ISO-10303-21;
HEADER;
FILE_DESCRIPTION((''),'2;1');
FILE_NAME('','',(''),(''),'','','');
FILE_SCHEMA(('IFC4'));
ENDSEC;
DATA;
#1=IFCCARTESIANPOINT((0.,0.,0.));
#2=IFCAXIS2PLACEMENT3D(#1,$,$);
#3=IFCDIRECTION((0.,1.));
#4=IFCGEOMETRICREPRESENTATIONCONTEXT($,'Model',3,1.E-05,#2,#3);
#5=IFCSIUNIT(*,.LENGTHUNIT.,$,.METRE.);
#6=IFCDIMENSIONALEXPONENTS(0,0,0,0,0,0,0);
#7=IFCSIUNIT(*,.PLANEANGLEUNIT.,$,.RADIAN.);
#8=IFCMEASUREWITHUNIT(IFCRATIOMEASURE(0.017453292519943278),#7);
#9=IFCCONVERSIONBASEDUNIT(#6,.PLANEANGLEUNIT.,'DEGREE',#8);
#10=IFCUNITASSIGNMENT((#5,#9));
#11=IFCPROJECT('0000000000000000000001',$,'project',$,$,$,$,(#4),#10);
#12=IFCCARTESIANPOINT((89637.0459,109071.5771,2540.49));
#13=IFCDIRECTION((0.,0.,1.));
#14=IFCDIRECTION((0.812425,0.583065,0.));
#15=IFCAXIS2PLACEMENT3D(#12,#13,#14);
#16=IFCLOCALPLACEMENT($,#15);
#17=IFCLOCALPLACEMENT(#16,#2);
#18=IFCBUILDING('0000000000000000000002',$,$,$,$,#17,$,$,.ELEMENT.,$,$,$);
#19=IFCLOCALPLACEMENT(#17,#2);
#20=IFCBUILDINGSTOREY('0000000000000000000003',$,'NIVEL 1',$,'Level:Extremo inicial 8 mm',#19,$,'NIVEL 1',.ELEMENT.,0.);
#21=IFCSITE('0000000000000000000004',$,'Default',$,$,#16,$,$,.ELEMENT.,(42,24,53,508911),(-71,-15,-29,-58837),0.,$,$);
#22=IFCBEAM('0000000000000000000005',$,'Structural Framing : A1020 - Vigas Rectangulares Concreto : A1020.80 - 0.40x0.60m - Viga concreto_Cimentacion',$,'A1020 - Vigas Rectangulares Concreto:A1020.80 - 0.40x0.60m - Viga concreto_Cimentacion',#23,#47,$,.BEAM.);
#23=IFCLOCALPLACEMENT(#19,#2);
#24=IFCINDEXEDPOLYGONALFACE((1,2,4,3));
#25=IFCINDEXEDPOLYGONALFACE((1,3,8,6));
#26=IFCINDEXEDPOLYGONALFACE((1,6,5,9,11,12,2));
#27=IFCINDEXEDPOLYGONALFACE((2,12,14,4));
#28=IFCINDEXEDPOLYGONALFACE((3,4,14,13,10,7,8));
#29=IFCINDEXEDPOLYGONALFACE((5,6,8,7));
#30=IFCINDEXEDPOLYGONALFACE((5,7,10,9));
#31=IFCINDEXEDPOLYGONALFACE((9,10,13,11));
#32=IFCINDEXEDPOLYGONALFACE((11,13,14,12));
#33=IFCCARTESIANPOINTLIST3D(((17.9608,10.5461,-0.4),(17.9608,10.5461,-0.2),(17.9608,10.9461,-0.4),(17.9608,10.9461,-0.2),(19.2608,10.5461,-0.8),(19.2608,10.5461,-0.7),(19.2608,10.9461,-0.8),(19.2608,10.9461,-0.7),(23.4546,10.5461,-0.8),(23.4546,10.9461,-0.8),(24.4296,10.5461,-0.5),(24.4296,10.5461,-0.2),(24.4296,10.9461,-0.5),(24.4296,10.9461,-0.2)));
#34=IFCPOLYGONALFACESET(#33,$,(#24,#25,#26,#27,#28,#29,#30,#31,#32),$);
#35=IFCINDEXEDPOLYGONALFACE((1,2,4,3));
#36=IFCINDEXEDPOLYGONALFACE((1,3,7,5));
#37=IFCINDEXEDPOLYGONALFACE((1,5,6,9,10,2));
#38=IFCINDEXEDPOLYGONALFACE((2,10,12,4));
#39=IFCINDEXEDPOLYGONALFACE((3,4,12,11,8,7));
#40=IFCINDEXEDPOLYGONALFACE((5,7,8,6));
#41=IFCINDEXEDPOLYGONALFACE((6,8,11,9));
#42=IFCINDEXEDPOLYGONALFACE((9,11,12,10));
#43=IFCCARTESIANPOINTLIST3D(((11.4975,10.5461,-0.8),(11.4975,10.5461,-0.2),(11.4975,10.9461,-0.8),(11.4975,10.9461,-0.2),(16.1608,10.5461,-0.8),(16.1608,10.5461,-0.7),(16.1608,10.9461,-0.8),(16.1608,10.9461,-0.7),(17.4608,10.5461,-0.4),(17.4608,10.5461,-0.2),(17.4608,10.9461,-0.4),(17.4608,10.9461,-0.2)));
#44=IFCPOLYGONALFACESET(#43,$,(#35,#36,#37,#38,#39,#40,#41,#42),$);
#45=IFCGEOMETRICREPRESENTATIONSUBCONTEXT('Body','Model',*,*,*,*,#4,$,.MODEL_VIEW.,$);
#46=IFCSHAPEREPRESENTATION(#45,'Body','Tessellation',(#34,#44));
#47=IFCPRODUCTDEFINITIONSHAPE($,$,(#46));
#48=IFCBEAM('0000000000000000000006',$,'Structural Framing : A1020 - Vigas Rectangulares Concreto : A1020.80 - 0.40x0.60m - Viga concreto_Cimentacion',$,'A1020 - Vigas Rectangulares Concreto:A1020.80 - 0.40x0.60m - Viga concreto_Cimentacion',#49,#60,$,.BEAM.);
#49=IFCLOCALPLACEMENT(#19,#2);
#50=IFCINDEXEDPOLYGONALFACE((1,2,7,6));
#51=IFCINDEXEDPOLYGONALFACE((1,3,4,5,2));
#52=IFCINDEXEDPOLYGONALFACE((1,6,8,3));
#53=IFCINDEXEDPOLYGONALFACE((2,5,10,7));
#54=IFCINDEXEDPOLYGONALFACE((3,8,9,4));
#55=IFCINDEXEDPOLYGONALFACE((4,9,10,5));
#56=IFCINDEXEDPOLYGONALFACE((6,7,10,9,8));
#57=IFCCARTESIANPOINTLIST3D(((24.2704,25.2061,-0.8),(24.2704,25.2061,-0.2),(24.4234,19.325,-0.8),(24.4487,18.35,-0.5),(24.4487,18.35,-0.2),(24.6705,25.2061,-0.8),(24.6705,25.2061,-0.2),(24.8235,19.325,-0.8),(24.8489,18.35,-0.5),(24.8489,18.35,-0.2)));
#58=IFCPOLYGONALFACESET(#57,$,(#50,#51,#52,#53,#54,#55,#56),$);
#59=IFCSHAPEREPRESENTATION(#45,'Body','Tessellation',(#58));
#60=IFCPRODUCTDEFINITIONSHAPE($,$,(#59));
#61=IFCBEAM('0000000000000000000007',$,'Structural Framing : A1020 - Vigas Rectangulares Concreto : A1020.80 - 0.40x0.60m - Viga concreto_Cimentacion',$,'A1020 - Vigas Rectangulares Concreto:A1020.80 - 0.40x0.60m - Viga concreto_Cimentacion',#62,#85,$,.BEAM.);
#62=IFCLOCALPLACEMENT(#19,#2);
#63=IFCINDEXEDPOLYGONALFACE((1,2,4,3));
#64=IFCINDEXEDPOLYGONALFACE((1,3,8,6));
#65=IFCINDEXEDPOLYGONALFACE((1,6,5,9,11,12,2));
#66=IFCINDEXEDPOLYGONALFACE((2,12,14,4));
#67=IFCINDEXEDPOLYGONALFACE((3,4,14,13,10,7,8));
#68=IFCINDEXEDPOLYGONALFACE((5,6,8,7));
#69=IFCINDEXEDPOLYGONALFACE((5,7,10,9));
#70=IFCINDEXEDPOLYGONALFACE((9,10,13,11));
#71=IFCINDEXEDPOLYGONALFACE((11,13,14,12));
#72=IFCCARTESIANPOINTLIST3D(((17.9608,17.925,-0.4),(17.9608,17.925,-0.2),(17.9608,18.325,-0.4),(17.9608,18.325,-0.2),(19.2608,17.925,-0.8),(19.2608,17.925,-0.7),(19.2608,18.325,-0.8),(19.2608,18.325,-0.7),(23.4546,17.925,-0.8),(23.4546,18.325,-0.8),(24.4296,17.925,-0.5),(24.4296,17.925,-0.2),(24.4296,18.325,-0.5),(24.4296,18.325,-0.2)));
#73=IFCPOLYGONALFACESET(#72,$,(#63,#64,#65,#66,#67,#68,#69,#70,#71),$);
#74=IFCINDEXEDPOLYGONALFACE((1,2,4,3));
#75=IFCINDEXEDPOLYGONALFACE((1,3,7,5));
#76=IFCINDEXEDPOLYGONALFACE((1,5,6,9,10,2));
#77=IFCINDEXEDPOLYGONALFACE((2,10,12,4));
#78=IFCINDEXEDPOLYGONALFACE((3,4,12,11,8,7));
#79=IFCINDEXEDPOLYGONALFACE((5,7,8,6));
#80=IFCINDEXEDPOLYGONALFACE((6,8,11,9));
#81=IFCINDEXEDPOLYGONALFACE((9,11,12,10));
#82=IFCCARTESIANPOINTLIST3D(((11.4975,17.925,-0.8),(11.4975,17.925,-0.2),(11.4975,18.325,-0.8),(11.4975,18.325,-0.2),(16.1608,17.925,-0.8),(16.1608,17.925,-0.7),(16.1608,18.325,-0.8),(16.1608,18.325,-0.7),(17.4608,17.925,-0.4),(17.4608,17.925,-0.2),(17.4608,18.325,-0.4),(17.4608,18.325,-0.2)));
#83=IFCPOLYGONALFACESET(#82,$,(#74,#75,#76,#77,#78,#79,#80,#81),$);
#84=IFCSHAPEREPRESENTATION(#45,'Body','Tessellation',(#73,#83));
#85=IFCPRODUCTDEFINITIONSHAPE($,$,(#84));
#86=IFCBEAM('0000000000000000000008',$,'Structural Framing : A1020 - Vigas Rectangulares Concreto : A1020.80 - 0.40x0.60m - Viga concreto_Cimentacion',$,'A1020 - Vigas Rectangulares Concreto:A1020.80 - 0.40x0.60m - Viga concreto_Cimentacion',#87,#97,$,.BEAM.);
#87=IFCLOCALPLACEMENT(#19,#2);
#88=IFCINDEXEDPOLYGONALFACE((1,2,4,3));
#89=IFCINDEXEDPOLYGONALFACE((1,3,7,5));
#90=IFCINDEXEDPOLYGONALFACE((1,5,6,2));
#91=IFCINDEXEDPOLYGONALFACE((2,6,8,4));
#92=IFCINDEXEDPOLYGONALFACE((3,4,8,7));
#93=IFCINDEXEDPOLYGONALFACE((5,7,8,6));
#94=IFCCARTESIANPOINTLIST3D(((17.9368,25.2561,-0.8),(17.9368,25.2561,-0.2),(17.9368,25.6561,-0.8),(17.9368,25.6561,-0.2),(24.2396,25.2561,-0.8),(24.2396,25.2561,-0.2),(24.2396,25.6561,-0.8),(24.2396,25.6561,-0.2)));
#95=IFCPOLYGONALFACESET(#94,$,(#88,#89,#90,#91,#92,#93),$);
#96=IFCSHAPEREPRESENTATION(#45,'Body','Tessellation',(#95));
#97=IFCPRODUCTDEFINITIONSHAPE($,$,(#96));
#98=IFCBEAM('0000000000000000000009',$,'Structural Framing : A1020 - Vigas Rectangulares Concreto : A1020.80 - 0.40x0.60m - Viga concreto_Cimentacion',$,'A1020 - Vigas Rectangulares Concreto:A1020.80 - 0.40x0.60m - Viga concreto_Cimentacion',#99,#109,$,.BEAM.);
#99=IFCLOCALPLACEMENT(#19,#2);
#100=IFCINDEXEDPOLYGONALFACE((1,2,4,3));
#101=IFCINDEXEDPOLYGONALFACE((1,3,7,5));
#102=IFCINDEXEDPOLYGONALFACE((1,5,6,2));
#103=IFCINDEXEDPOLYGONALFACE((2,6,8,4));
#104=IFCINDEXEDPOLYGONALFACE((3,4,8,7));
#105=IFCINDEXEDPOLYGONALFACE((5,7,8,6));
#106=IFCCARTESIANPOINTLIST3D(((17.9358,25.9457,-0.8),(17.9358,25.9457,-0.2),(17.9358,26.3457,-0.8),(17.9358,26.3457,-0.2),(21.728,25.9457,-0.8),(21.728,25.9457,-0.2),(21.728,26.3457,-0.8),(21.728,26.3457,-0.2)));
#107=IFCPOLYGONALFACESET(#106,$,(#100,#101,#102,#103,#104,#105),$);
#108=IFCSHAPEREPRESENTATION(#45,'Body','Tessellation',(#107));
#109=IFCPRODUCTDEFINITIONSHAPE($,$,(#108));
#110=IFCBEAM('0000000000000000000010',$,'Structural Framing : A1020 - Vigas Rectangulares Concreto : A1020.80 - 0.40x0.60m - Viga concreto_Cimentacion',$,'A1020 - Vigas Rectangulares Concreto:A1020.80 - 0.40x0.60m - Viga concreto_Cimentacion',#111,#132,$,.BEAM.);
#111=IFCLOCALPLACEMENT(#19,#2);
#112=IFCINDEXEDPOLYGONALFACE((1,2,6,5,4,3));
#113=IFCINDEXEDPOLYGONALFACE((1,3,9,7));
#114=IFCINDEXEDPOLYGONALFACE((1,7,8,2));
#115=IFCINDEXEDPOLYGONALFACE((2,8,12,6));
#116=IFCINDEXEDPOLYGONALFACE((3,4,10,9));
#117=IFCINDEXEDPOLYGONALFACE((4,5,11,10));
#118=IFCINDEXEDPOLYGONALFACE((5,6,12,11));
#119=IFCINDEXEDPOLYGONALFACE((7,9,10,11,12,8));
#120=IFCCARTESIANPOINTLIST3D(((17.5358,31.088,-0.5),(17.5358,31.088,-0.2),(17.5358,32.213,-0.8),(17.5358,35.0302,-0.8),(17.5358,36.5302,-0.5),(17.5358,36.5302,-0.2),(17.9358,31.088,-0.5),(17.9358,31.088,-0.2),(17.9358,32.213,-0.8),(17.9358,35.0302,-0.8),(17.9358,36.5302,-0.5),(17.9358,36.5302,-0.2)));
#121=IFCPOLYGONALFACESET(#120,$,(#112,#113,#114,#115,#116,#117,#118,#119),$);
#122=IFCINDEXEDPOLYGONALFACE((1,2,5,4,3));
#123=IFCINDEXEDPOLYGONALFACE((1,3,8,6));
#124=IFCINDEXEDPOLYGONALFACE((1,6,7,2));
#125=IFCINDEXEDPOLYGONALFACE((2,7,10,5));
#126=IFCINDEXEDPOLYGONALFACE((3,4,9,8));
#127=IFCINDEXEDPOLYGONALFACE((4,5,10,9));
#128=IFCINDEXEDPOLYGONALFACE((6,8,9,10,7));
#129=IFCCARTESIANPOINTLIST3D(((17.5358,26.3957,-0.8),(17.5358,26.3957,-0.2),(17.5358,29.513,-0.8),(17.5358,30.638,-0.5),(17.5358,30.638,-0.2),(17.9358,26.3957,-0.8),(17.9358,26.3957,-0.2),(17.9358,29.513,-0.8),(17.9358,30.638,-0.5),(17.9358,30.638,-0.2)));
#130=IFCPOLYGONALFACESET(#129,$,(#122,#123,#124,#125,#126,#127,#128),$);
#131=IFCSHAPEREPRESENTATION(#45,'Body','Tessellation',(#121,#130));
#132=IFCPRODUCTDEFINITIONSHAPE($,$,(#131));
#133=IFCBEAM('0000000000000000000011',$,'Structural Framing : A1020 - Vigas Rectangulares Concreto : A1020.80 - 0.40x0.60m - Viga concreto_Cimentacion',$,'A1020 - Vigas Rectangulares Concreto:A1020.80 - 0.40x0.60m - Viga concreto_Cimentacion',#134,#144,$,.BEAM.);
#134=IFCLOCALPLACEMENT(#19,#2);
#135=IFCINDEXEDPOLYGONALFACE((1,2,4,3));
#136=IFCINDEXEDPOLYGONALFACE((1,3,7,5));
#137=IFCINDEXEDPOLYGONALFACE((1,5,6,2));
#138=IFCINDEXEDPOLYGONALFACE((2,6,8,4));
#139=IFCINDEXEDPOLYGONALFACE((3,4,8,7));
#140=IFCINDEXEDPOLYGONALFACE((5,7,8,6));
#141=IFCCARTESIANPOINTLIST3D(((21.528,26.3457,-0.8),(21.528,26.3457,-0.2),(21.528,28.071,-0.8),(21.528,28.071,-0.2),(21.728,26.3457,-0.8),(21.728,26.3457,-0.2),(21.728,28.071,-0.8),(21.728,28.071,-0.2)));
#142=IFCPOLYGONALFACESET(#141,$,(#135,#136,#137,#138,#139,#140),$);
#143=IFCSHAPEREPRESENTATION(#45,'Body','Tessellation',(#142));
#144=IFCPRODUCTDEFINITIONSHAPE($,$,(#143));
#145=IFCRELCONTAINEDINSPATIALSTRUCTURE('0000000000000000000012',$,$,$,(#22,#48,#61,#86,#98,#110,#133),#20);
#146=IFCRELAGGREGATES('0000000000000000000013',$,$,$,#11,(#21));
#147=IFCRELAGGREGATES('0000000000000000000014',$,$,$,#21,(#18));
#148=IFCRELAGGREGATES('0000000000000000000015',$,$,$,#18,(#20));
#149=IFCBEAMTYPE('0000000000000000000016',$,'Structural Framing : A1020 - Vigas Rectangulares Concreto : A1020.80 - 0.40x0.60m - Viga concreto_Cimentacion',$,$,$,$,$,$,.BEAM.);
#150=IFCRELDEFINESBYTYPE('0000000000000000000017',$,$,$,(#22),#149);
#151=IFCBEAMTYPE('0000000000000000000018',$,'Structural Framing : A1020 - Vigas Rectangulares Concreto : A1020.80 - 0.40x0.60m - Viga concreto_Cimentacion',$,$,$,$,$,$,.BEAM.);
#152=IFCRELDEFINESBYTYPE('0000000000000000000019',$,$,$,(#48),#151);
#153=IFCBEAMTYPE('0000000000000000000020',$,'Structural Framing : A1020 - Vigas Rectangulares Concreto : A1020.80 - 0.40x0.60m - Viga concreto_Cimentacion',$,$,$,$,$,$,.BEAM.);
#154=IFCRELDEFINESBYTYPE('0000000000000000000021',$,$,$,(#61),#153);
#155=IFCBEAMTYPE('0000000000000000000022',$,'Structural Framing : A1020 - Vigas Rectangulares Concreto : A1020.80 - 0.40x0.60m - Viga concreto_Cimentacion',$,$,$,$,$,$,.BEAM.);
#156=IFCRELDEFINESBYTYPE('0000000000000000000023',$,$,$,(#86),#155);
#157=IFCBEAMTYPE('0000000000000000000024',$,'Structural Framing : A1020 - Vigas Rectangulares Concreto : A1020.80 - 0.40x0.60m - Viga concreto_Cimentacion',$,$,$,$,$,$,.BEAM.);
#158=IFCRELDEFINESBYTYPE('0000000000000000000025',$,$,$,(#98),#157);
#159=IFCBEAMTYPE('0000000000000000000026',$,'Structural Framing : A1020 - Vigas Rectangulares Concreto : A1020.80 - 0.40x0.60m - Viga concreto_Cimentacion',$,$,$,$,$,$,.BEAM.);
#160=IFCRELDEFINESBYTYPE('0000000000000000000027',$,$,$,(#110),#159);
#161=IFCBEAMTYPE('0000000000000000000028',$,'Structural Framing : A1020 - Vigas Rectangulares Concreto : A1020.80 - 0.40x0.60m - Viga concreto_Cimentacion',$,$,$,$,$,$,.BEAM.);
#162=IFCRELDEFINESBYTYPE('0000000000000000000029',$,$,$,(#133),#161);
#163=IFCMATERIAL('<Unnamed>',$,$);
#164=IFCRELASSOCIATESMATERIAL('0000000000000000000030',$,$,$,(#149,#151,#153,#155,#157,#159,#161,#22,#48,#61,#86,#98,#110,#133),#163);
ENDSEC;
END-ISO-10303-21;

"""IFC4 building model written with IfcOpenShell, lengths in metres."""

from ifc_helpers import new_model, entity, si_unit, converted_unit, direction, frame, frame_2d, origin, place, context, subcontext, project, spatial, polyline, segment, composite_curve, rectangle, outline, extrude, clip, halfspace, bounded_halfspace, source, transform, mapped, material, material_profile, profile_set, profile_usage, type_object, type_shapes, element, save


model = new_model("IFC4")

# Units and contexts
model_context = context("Model", 3, precision=1e-05, world=origin(), true_north=direction((0.0, 1.0)))
body_context = subcontext(model_context, "Body", "Model", "MODEL_VIEW")
ifc_project = project(units=[si_unit("LENGTHUNIT", "METRE"), converted_unit("PLANEANGLEUNIT", "DEGREE", entity("IfcRatioMeasure", 0.017453292519943278), si_unit("PLANEANGLEUNIT", "RADIAN"), dimensions=[0, 0, 0, 0, 0, 0, 0])], contexts=[model_context])

# Site, building, storey
site_placement = place(None, frame((89637.0459, 109071.5771, 2540.49), z_axis=(0.0, 0.0, 1.0), x_axis=(0.812425, 0.583065, 0.0)))
site = spatial("IfcSite", under=ifc_project, at=site_placement, Name="Default", CompositionType="ELEMENT", RefLatitude=(42, 24, 53, 508911), RefLongitude=(-71, -15, -29, -58837), RefElevation=0.0)
building_placement = place(site_placement, origin())
building = spatial("IfcBuilding", under=site, at=building_placement, CompositionType="ELEMENT")
storey_placement = place(building_placement, origin())
storey = spatial("IfcBuildingStorey", under=building, at=storey_placement, Name="NIVEL 1", ObjectType="Level:Extremo inicial 8 mm", LongName="NIVEL 1", CompositionType="ELEMENT", Elevation=0.0)

# Shared definitions
ifc_material_1 = material(Name="<Unnamed>")

# Beams
ifc_material_profile_1 = material_profile(ifc_material_1, outline(composite_curve([segment(polyline([(-0.2, 0.3, 0.0), (0.2, 0.3, 0.0)]), True, "CONTINUOUS"), segment(polyline([(0.2, 0.3, 0.0), (0.2, -0.3, 0.0)]), True, "CONTINUOUS"), segment(polyline([(0.2, -0.3, 0.0), (-0.2, -0.3, 0.0)]), True, "CONTINUOUS"), segment(polyline([(-0.2, -0.3, 0.0), (-0.2, 0.3, 0.0)]), True, "CONTINUOUS")], self_intersect=False), kind="CURVE"), Name="A1020.80 - 0.40x0.60m - Viga concreto_Cimentacion")
ifc_material_profile_2 = material_profile(ifc_material_1, outline(composite_curve([segment(polyline([(6.4409, -0.2, 0.3), (6.4409, -0.2, -0.3)]), True, "CONTINUOUS"), segment(polyline([(6.4409, -0.2, -0.3), (6.4409, 0.2, -0.3)]), True, "CONTINUOUS"), segment(polyline([(6.4409, 0.2, -0.3), (6.4409, 0.2, 0.3)]), True, "CONTINUOUS"), segment(polyline([(6.4409, 0.2, 0.3), (6.4409, -0.2, 0.3)]), True, "CONTINUOUS")], self_intersect=False), kind="CURVE"), Name="A1020.80 - 0.40x0.60m - Viga concreto_Cimentacion")
ifc_profile_set_1 = profile_set([ifc_material_profile_1, ifc_material_profile_2], Name="A1020.80 - 0.40x0.60m - Viga concreto_Cimentacion")
ifc_profile_usage_1 = profile_usage(ifc_profile_set_1, cardinal=8)
beam_type_1 = type_object("IfcBeamType", Name="Structural Framing : A1020 - Vigas Rectangulares Concreto : A1020.80 - 0.40x0.60m - Viga concreto_Cimentacion", PredefinedType="BEAM", material=ifc_profile_set_1)
shared_shape_1 = source(origin(), body_context, "Body", "SweptSolid", [
    clip(clip(clip(extrude(rectangle(XDim=0.6, YDim=0.4, at=frame_2d((0.0, 0.0), x_axis=(0.0, 1.0))), frame((17.9608, 10.7461, -0.5), z_axis=(1.0, 0.0, 0.0), x_axis=(0.0, 1.0, 0.0)), (0.0, 0.0, 1.0), 6.4688), halfspace(frame((23.4546, 10.7461, -0.8), z_axis=(0.294086, 0.0, -0.955779), x_axis=(0.0, -1.0, 0.0)), False)), bounded_halfspace(frame((19.2608, 10.7461, -0.7), z_axis=(-0.22486, 0.0, -0.974391), x_axis=(0.0, 1.0, 0.0)), False, frame((17.9608, 10.7461, -0.5), z_axis=(1.0, 0.0, 0.0), x_axis=(0.0, 1.0, 0.0)), polyline([(-0.2, -0.2), (-0.2, 0.1), (0.2, 0.1), (0.2, -0.2), (-0.2, -0.2)]))), bounded_halfspace(frame((19.2608, 9.1961, -0.7), z_axis=(-1.0, 0.0, 0.0), x_axis=(0.0, 0.0, -1.0)), False, frame((17.9608, 10.7461, -0.5), z_axis=(1.0, 0.0, 0.0), x_axis=(0.0, 1.0, 0.0)), polyline([(-0.2, -0.3), (-0.2, -0.2), (0.2, -0.2), (0.2, -0.3), (-0.2, -0.3)]))),
    clip(clip(extrude(rectangle(XDim=0.6, YDim=0.4, at=frame_2d((0.0, 0.0), x_axis=(0.0, 1.0))), frame((11.4975, 10.7461, -0.5), z_axis=(1.0, 0.0, 0.0), x_axis=(0.0, 1.0, 0.0)), (0.0, 0.0, 1.0), 5.9633), bounded_halfspace(frame((16.1608, 10.7461, -0.7), z_axis=(0.22486, 0.0, -0.974391), x_axis=(0.0, -1.0, 0.0)), False, frame((11.4975, 10.7461, -0.5), z_axis=(1.0, 0.0, 0.0), x_axis=(0.0, 1.0, 0.0)), polyline([(-0.2, 0.1), (-0.2, -0.2), (0.2, -0.2), (0.2, 0.1), (-0.2, 0.1)]))), bounded_halfspace(frame((16.1608, 12.2961, -0.7), z_axis=(1.0, 0.0, 0.0), x_axis=(0.0, 0.0, -1.0)), False, frame((11.4975, 10.7461, -0.5), z_axis=(1.0, 0.0, 0.0), x_axis=(0.0, 1.0, 0.0)), polyline([(-0.2, -0.2), (-0.2, -0.3), (0.2, -0.3), (0.2, -0.2), (-0.2, -0.2)]))),
])
type_shapes(beam_type_1, [shared_shape_1])
beam_1_placement = place(storey_placement, origin())
element("IfcBeam", 1, at=beam_1_placement, inside=storey, type_object=beam_type_1, material=ifc_profile_usage_1, Name="Structural Framing : A1020 - Vigas Rectangulares Concreto : A1020.80 - 0.40x0.60m - Viga concreto_Cimentacion", ObjectType="A1020 - Vigas Rectangulares Concreto:A1020.80 - 0.40x0.60m - Viga concreto_Cimentacion", PredefinedType="BEAM", context=body_context, shape_type="MappedRepresentation", body=[
    mapped(shared_shape_1, transform((0.0, 0.0, 0.0), scale=1.0)),
])
ifc_profile_usage_2 = profile_usage(ifc_profile_set_1, cardinal=8)
beam_type_2 = type_object("IfcBeamType", Name="Structural Framing : A1020 - Vigas Rectangulares Concreto : A1020.80 - 0.40x0.60m - Viga concreto_Cimentacion", PredefinedType="BEAM", material=ifc_profile_set_1)
shared_shape_2 = source(origin(), body_context, "Body", "SweptSolid", [
    clip(clip(clip(extrude(rectangle(XDim=0.6, YDim=0.4, at=frame_2d((0.0, 0.0), x_axis=(0.0, 1.0))), frame((24.6489, 18.3448, -0.5), z_axis=(-0.026001, 0.999662, 0.0), x_axis=(0.999662, 0.026001, 0.0)), (0.0, 0.0, 1.0), 6.8688), halfspace(frame((24.6546, 19.325, -0.8), z_axis=(0.0, -0.294086, -0.955779), x_axis=(-1.0, 0.0, 0.0)), False)), halfspace(frame((24.8796, 18.35, 3.0), z_axis=(0.0, -1.0, 0.0), x_axis=(0.0, 0.0, -1.0)), False)), halfspace(frame((24.2396, 25.2061, 3.0), z_axis=(0.0, 1.0, 0.0), x_axis=(0.0, 0.0, -1.0)), False)),
])
type_shapes(beam_type_2, [shared_shape_2])
beam_2_placement = place(storey_placement, origin())
element("IfcBeam", 2, at=beam_2_placement, inside=storey, type_object=beam_type_2, material=ifc_profile_usage_2, Name="Structural Framing : A1020 - Vigas Rectangulares Concreto : A1020.80 - 0.40x0.60m - Viga concreto_Cimentacion", ObjectType="A1020 - Vigas Rectangulares Concreto:A1020.80 - 0.40x0.60m - Viga concreto_Cimentacion", PredefinedType="BEAM", context=body_context, shape_type="MappedRepresentation", body=[
    mapped(shared_shape_2, transform((0.0, 0.0, 0.0), scale=1.0)),
])
ifc_profile_usage_3 = profile_usage(ifc_profile_set_1, cardinal=8)
beam_type_3 = type_object("IfcBeamType", Name="Structural Framing : A1020 - Vigas Rectangulares Concreto : A1020.80 - 0.40x0.60m - Viga concreto_Cimentacion", PredefinedType="BEAM", material=ifc_profile_set_1)
shared_shape_3 = source(origin(), body_context, "Body", "SweptSolid", [
    clip(clip(clip(extrude(rectangle(XDim=0.6, YDim=0.4, at=frame_2d((0.0, 0.0), x_axis=(0.0, 1.0))), frame((17.9608, 18.125, -0.5), z_axis=(1.0, 0.0, 0.0), x_axis=(0.0, 1.0, 0.0)), (0.0, 0.0, 1.0), 6.4688), halfspace(frame((23.4546, 18.125, -0.8), z_axis=(0.294086, 0.0, -0.955779), x_axis=(0.0, -1.0, 0.0)), False)), bounded_halfspace(frame((19.2608, 18.125, -0.7), z_axis=(-0.22486, 0.0, -0.974391), x_axis=(0.0, 1.0, 0.0)), False, frame((17.9608, 18.125, -0.5), z_axis=(1.0, 0.0, 0.0), x_axis=(0.0, 1.0, 0.0)), polyline([(-0.2, -0.2), (-0.2, 0.1), (0.2, 0.1), (0.2, -0.2), (-0.2, -0.2)]))), bounded_halfspace(frame((19.2608, 16.575, -0.7), z_axis=(-1.0, 0.0, 0.0), x_axis=(0.0, 0.0, -1.0)), False, frame((17.9608, 18.125, -0.5), z_axis=(1.0, 0.0, 0.0), x_axis=(0.0, 1.0, 0.0)), polyline([(-0.2, -0.3), (-0.2, -0.2), (0.2, -0.2), (0.2, -0.3), (-0.2, -0.3)]))),
    clip(clip(extrude(rectangle(XDim=0.6, YDim=0.4, at=frame_2d((0.0, 0.0), x_axis=(0.0, 1.0))), frame((11.4975, 18.125, -0.5), z_axis=(1.0, 0.0, 0.0), x_axis=(0.0, 1.0, 0.0)), (0.0, 0.0, 1.0), 5.9633), bounded_halfspace(frame((16.1608, 18.125, -0.7), z_axis=(0.22486, 0.0, -0.974391), x_axis=(0.0, -1.0, 0.0)), False, frame((11.4975, 18.125, -0.5), z_axis=(1.0, 0.0, 0.0), x_axis=(0.0, 1.0, 0.0)), polyline([(-0.2, 0.1), (-0.2, -0.2), (0.2, -0.2), (0.2, 0.1), (-0.2, 0.1)]))), bounded_halfspace(frame((16.1608, 19.675, -0.7), z_axis=(1.0, 0.0, 0.0), x_axis=(0.0, 0.0, -1.0)), False, frame((11.4975, 18.125, -0.5), z_axis=(1.0, 0.0, 0.0), x_axis=(0.0, 1.0, 0.0)), polyline([(-0.2, -0.2), (-0.2, -0.3), (0.2, -0.3), (0.2, -0.2), (-0.2, -0.2)]))),
])
type_shapes(beam_type_3, [shared_shape_3])
beam_3_placement = place(storey_placement, origin())
element("IfcBeam", 3, at=beam_3_placement, inside=storey, type_object=beam_type_3, material=ifc_profile_usage_3, Name="Structural Framing : A1020 - Vigas Rectangulares Concreto : A1020.80 - 0.40x0.60m - Viga concreto_Cimentacion", ObjectType="A1020 - Vigas Rectangulares Concreto:A1020.80 - 0.40x0.60m - Viga concreto_Cimentacion", PredefinedType="BEAM", context=body_context, shape_type="MappedRepresentation", body=[
    mapped(shared_shape_3, transform((0.0, 0.0, 0.0), scale=1.0)),
])
ifc_profile_usage_4 = profile_usage(ifc_profile_set_1, cardinal=8)
beam_type_4 = type_object("IfcBeamType", Name="Structural Framing : A1020 - Vigas Rectangulares Concreto : A1020.80 - 0.40x0.60m - Viga concreto_Cimentacion", PredefinedType="BEAM", material=ifc_profile_set_1)
shared_shape_4 = source(origin(), body_context, "Body", "SweptSolid", [
    extrude(rectangle(XDim=0.6, YDim=0.4, at=frame_2d((0.0, 0.0), x_axis=(1.0, 0.0))), frame((17.9368, 25.4561, -0.5), z_axis=(1.0, 0.0, 0.0), x_axis=(0.0, 0.0, -1.0)), (0.0, 0.0, 1.0), 6.3028),
])
type_shapes(beam_type_4, [shared_shape_4])
beam_4_placement = place(storey_placement, origin())
element("IfcBeam", 4, at=beam_4_placement, inside=storey, type_object=beam_type_4, material=ifc_profile_usage_4, Name="Structural Framing : A1020 - Vigas Rectangulares Concreto : A1020.80 - 0.40x0.60m - Viga concreto_Cimentacion", ObjectType="A1020 - Vigas Rectangulares Concreto:A1020.80 - 0.40x0.60m - Viga concreto_Cimentacion", PredefinedType="BEAM", context=body_context, shape_type="MappedRepresentation", body=[
    mapped(shared_shape_4, transform((0.0, 0.0, 0.0), scale=1.0)),
])
ifc_profile_usage_5 = profile_usage(ifc_profile_set_1, cardinal=8)
beam_type_5 = type_object("IfcBeamType", Name="Structural Framing : A1020 - Vigas Rectangulares Concreto : A1020.80 - 0.40x0.60m - Viga concreto_Cimentacion", PredefinedType="BEAM", material=ifc_profile_set_1)
shared_shape_5 = source(origin(), body_context, "Body", "SweptSolid", [
    extrude(rectangle(XDim=0.6, YDim=0.4, at=frame_2d((0.0, 0.0), x_axis=(1.0, 0.0))), frame((17.9358, 26.1457, -0.5), z_axis=(1.0, 0.0, 0.0), x_axis=(0.0, 0.0, -1.0)), (0.0, 0.0, 1.0), 3.7922),
])
type_shapes(beam_type_5, [shared_shape_5])
beam_5_placement = place(storey_placement, origin())
element("IfcBeam", 5, at=beam_5_placement, inside=storey, type_object=beam_type_5, material=ifc_profile_usage_5, Name="Structural Framing : A1020 - Vigas Rectangulares Concreto : A1020.80 - 0.40x0.60m - Viga concreto_Cimentacion", ObjectType="A1020 - Vigas Rectangulares Concreto:A1020.80 - 0.40x0.60m - Viga concreto_Cimentacion", PredefinedType="BEAM", context=body_context, shape_type="MappedRepresentation", body=[
    mapped(shared_shape_5, transform((0.0, 0.0, 0.0), scale=1.0)),
])
ifc_profile_usage_6 = profile_usage(ifc_profile_set_1, cardinal=8)
beam_type_6 = type_object("IfcBeamType", Name="Structural Framing : A1020 - Vigas Rectangulares Concreto : A1020.80 - 0.40x0.60m - Viga concreto_Cimentacion", PredefinedType="BEAM", material=ifc_profile_set_1)
shared_shape_6 = source(origin(), body_context, "Body", "SweptSolid", [
    clip(clip(extrude(rectangle(XDim=0.6, YDim=0.4, at=frame_2d((0.0, 0.0), x_axis=(0.0, 1.0))), frame((17.7358, 31.088, -0.5), z_axis=(0.0, 1.0, 0.0), x_axis=(-1.0, 0.0, 0.0)), (0.0, 0.0, 1.0), 5.4422), halfspace(frame((17.6608, 35.0302, -0.8), z_axis=(0.0, 0.196116, -0.980581), x_axis=(1.0, 0.0, 0.0)), False)), halfspace(frame((17.7108, 32.213, -0.8), z_axis=(0.0, -0.257663, -0.966235), x_axis=(-1.0, 0.0, 0.0)), False)),
    clip(extrude(rectangle(XDim=0.6, YDim=0.4, at=frame_2d((0.0, 0.0), x_axis=(0.0, 1.0))), frame((17.7358, 26.3957, -0.5), z_axis=(0.0, 1.0, 0.0), x_axis=(-1.0, 0.0, 0.0)), (0.0, 0.0, 1.0), 4.2424), halfspace(frame((17.7108, 29.513, -0.8), z_axis=(0.0, 0.257663, -0.966235), x_axis=(1.0, 0.0, 0.0)), False)),
])
type_shapes(beam_type_6, [shared_shape_6])
beam_6_placement = place(storey_placement, origin())
element("IfcBeam", 6, at=beam_6_placement, inside=storey, type_object=beam_type_6, material=ifc_profile_usage_6, Name="Structural Framing : A1020 - Vigas Rectangulares Concreto : A1020.80 - 0.40x0.60m - Viga concreto_Cimentacion", ObjectType="A1020 - Vigas Rectangulares Concreto:A1020.80 - 0.40x0.60m - Viga concreto_Cimentacion", PredefinedType="BEAM", context=body_context, shape_type="MappedRepresentation", body=[
    mapped(shared_shape_6, transform((0.0, 0.0, 0.0), scale=1.0)),
])
ifc_profile_usage_7 = profile_usage(ifc_profile_set_1, cardinal=8)
beam_type_7 = type_object("IfcBeamType", Name="Structural Framing : A1020 - Vigas Rectangulares Concreto : A1020.80 - 0.40x0.60m - Viga concreto_Cimentacion", PredefinedType="BEAM", material=ifc_profile_set_1)
shared_shape_7 = source(origin(), body_context, "Body", "SweptSolid", [
    extrude(rectangle(XDim=0.6, YDim=0.2, at=frame_2d((0.0, 0.0), x_axis=(0.0, 1.0))), frame((21.628, 26.3457, -0.5), z_axis=(0.0, 1.0, 0.0), x_axis=(-1.0, 0.0, 0.0)), (0.0, 0.0, 1.0), 1.7253),
])
type_shapes(beam_type_7, [shared_shape_7])
beam_7_placement = place(storey_placement, origin())
element("IfcBeam", 7, at=beam_7_placement, inside=storey, type_object=beam_type_7, material=ifc_profile_usage_7, Name="Structural Framing : A1020 - Vigas Rectangulares Concreto : A1020.80 - 0.40x0.60m - Viga concreto_Cimentacion", ObjectType="A1020 - Vigas Rectangulares Concreto:A1020.80 - 0.40x0.60m - Viga concreto_Cimentacion", PredefinedType="BEAM", context=body_context, shape_type="MappedRepresentation", body=[
    mapped(shared_shape_7, transform((0.0, 0.0, 0.0), scale=1.0)),
])

save(model, "model.ifc")
